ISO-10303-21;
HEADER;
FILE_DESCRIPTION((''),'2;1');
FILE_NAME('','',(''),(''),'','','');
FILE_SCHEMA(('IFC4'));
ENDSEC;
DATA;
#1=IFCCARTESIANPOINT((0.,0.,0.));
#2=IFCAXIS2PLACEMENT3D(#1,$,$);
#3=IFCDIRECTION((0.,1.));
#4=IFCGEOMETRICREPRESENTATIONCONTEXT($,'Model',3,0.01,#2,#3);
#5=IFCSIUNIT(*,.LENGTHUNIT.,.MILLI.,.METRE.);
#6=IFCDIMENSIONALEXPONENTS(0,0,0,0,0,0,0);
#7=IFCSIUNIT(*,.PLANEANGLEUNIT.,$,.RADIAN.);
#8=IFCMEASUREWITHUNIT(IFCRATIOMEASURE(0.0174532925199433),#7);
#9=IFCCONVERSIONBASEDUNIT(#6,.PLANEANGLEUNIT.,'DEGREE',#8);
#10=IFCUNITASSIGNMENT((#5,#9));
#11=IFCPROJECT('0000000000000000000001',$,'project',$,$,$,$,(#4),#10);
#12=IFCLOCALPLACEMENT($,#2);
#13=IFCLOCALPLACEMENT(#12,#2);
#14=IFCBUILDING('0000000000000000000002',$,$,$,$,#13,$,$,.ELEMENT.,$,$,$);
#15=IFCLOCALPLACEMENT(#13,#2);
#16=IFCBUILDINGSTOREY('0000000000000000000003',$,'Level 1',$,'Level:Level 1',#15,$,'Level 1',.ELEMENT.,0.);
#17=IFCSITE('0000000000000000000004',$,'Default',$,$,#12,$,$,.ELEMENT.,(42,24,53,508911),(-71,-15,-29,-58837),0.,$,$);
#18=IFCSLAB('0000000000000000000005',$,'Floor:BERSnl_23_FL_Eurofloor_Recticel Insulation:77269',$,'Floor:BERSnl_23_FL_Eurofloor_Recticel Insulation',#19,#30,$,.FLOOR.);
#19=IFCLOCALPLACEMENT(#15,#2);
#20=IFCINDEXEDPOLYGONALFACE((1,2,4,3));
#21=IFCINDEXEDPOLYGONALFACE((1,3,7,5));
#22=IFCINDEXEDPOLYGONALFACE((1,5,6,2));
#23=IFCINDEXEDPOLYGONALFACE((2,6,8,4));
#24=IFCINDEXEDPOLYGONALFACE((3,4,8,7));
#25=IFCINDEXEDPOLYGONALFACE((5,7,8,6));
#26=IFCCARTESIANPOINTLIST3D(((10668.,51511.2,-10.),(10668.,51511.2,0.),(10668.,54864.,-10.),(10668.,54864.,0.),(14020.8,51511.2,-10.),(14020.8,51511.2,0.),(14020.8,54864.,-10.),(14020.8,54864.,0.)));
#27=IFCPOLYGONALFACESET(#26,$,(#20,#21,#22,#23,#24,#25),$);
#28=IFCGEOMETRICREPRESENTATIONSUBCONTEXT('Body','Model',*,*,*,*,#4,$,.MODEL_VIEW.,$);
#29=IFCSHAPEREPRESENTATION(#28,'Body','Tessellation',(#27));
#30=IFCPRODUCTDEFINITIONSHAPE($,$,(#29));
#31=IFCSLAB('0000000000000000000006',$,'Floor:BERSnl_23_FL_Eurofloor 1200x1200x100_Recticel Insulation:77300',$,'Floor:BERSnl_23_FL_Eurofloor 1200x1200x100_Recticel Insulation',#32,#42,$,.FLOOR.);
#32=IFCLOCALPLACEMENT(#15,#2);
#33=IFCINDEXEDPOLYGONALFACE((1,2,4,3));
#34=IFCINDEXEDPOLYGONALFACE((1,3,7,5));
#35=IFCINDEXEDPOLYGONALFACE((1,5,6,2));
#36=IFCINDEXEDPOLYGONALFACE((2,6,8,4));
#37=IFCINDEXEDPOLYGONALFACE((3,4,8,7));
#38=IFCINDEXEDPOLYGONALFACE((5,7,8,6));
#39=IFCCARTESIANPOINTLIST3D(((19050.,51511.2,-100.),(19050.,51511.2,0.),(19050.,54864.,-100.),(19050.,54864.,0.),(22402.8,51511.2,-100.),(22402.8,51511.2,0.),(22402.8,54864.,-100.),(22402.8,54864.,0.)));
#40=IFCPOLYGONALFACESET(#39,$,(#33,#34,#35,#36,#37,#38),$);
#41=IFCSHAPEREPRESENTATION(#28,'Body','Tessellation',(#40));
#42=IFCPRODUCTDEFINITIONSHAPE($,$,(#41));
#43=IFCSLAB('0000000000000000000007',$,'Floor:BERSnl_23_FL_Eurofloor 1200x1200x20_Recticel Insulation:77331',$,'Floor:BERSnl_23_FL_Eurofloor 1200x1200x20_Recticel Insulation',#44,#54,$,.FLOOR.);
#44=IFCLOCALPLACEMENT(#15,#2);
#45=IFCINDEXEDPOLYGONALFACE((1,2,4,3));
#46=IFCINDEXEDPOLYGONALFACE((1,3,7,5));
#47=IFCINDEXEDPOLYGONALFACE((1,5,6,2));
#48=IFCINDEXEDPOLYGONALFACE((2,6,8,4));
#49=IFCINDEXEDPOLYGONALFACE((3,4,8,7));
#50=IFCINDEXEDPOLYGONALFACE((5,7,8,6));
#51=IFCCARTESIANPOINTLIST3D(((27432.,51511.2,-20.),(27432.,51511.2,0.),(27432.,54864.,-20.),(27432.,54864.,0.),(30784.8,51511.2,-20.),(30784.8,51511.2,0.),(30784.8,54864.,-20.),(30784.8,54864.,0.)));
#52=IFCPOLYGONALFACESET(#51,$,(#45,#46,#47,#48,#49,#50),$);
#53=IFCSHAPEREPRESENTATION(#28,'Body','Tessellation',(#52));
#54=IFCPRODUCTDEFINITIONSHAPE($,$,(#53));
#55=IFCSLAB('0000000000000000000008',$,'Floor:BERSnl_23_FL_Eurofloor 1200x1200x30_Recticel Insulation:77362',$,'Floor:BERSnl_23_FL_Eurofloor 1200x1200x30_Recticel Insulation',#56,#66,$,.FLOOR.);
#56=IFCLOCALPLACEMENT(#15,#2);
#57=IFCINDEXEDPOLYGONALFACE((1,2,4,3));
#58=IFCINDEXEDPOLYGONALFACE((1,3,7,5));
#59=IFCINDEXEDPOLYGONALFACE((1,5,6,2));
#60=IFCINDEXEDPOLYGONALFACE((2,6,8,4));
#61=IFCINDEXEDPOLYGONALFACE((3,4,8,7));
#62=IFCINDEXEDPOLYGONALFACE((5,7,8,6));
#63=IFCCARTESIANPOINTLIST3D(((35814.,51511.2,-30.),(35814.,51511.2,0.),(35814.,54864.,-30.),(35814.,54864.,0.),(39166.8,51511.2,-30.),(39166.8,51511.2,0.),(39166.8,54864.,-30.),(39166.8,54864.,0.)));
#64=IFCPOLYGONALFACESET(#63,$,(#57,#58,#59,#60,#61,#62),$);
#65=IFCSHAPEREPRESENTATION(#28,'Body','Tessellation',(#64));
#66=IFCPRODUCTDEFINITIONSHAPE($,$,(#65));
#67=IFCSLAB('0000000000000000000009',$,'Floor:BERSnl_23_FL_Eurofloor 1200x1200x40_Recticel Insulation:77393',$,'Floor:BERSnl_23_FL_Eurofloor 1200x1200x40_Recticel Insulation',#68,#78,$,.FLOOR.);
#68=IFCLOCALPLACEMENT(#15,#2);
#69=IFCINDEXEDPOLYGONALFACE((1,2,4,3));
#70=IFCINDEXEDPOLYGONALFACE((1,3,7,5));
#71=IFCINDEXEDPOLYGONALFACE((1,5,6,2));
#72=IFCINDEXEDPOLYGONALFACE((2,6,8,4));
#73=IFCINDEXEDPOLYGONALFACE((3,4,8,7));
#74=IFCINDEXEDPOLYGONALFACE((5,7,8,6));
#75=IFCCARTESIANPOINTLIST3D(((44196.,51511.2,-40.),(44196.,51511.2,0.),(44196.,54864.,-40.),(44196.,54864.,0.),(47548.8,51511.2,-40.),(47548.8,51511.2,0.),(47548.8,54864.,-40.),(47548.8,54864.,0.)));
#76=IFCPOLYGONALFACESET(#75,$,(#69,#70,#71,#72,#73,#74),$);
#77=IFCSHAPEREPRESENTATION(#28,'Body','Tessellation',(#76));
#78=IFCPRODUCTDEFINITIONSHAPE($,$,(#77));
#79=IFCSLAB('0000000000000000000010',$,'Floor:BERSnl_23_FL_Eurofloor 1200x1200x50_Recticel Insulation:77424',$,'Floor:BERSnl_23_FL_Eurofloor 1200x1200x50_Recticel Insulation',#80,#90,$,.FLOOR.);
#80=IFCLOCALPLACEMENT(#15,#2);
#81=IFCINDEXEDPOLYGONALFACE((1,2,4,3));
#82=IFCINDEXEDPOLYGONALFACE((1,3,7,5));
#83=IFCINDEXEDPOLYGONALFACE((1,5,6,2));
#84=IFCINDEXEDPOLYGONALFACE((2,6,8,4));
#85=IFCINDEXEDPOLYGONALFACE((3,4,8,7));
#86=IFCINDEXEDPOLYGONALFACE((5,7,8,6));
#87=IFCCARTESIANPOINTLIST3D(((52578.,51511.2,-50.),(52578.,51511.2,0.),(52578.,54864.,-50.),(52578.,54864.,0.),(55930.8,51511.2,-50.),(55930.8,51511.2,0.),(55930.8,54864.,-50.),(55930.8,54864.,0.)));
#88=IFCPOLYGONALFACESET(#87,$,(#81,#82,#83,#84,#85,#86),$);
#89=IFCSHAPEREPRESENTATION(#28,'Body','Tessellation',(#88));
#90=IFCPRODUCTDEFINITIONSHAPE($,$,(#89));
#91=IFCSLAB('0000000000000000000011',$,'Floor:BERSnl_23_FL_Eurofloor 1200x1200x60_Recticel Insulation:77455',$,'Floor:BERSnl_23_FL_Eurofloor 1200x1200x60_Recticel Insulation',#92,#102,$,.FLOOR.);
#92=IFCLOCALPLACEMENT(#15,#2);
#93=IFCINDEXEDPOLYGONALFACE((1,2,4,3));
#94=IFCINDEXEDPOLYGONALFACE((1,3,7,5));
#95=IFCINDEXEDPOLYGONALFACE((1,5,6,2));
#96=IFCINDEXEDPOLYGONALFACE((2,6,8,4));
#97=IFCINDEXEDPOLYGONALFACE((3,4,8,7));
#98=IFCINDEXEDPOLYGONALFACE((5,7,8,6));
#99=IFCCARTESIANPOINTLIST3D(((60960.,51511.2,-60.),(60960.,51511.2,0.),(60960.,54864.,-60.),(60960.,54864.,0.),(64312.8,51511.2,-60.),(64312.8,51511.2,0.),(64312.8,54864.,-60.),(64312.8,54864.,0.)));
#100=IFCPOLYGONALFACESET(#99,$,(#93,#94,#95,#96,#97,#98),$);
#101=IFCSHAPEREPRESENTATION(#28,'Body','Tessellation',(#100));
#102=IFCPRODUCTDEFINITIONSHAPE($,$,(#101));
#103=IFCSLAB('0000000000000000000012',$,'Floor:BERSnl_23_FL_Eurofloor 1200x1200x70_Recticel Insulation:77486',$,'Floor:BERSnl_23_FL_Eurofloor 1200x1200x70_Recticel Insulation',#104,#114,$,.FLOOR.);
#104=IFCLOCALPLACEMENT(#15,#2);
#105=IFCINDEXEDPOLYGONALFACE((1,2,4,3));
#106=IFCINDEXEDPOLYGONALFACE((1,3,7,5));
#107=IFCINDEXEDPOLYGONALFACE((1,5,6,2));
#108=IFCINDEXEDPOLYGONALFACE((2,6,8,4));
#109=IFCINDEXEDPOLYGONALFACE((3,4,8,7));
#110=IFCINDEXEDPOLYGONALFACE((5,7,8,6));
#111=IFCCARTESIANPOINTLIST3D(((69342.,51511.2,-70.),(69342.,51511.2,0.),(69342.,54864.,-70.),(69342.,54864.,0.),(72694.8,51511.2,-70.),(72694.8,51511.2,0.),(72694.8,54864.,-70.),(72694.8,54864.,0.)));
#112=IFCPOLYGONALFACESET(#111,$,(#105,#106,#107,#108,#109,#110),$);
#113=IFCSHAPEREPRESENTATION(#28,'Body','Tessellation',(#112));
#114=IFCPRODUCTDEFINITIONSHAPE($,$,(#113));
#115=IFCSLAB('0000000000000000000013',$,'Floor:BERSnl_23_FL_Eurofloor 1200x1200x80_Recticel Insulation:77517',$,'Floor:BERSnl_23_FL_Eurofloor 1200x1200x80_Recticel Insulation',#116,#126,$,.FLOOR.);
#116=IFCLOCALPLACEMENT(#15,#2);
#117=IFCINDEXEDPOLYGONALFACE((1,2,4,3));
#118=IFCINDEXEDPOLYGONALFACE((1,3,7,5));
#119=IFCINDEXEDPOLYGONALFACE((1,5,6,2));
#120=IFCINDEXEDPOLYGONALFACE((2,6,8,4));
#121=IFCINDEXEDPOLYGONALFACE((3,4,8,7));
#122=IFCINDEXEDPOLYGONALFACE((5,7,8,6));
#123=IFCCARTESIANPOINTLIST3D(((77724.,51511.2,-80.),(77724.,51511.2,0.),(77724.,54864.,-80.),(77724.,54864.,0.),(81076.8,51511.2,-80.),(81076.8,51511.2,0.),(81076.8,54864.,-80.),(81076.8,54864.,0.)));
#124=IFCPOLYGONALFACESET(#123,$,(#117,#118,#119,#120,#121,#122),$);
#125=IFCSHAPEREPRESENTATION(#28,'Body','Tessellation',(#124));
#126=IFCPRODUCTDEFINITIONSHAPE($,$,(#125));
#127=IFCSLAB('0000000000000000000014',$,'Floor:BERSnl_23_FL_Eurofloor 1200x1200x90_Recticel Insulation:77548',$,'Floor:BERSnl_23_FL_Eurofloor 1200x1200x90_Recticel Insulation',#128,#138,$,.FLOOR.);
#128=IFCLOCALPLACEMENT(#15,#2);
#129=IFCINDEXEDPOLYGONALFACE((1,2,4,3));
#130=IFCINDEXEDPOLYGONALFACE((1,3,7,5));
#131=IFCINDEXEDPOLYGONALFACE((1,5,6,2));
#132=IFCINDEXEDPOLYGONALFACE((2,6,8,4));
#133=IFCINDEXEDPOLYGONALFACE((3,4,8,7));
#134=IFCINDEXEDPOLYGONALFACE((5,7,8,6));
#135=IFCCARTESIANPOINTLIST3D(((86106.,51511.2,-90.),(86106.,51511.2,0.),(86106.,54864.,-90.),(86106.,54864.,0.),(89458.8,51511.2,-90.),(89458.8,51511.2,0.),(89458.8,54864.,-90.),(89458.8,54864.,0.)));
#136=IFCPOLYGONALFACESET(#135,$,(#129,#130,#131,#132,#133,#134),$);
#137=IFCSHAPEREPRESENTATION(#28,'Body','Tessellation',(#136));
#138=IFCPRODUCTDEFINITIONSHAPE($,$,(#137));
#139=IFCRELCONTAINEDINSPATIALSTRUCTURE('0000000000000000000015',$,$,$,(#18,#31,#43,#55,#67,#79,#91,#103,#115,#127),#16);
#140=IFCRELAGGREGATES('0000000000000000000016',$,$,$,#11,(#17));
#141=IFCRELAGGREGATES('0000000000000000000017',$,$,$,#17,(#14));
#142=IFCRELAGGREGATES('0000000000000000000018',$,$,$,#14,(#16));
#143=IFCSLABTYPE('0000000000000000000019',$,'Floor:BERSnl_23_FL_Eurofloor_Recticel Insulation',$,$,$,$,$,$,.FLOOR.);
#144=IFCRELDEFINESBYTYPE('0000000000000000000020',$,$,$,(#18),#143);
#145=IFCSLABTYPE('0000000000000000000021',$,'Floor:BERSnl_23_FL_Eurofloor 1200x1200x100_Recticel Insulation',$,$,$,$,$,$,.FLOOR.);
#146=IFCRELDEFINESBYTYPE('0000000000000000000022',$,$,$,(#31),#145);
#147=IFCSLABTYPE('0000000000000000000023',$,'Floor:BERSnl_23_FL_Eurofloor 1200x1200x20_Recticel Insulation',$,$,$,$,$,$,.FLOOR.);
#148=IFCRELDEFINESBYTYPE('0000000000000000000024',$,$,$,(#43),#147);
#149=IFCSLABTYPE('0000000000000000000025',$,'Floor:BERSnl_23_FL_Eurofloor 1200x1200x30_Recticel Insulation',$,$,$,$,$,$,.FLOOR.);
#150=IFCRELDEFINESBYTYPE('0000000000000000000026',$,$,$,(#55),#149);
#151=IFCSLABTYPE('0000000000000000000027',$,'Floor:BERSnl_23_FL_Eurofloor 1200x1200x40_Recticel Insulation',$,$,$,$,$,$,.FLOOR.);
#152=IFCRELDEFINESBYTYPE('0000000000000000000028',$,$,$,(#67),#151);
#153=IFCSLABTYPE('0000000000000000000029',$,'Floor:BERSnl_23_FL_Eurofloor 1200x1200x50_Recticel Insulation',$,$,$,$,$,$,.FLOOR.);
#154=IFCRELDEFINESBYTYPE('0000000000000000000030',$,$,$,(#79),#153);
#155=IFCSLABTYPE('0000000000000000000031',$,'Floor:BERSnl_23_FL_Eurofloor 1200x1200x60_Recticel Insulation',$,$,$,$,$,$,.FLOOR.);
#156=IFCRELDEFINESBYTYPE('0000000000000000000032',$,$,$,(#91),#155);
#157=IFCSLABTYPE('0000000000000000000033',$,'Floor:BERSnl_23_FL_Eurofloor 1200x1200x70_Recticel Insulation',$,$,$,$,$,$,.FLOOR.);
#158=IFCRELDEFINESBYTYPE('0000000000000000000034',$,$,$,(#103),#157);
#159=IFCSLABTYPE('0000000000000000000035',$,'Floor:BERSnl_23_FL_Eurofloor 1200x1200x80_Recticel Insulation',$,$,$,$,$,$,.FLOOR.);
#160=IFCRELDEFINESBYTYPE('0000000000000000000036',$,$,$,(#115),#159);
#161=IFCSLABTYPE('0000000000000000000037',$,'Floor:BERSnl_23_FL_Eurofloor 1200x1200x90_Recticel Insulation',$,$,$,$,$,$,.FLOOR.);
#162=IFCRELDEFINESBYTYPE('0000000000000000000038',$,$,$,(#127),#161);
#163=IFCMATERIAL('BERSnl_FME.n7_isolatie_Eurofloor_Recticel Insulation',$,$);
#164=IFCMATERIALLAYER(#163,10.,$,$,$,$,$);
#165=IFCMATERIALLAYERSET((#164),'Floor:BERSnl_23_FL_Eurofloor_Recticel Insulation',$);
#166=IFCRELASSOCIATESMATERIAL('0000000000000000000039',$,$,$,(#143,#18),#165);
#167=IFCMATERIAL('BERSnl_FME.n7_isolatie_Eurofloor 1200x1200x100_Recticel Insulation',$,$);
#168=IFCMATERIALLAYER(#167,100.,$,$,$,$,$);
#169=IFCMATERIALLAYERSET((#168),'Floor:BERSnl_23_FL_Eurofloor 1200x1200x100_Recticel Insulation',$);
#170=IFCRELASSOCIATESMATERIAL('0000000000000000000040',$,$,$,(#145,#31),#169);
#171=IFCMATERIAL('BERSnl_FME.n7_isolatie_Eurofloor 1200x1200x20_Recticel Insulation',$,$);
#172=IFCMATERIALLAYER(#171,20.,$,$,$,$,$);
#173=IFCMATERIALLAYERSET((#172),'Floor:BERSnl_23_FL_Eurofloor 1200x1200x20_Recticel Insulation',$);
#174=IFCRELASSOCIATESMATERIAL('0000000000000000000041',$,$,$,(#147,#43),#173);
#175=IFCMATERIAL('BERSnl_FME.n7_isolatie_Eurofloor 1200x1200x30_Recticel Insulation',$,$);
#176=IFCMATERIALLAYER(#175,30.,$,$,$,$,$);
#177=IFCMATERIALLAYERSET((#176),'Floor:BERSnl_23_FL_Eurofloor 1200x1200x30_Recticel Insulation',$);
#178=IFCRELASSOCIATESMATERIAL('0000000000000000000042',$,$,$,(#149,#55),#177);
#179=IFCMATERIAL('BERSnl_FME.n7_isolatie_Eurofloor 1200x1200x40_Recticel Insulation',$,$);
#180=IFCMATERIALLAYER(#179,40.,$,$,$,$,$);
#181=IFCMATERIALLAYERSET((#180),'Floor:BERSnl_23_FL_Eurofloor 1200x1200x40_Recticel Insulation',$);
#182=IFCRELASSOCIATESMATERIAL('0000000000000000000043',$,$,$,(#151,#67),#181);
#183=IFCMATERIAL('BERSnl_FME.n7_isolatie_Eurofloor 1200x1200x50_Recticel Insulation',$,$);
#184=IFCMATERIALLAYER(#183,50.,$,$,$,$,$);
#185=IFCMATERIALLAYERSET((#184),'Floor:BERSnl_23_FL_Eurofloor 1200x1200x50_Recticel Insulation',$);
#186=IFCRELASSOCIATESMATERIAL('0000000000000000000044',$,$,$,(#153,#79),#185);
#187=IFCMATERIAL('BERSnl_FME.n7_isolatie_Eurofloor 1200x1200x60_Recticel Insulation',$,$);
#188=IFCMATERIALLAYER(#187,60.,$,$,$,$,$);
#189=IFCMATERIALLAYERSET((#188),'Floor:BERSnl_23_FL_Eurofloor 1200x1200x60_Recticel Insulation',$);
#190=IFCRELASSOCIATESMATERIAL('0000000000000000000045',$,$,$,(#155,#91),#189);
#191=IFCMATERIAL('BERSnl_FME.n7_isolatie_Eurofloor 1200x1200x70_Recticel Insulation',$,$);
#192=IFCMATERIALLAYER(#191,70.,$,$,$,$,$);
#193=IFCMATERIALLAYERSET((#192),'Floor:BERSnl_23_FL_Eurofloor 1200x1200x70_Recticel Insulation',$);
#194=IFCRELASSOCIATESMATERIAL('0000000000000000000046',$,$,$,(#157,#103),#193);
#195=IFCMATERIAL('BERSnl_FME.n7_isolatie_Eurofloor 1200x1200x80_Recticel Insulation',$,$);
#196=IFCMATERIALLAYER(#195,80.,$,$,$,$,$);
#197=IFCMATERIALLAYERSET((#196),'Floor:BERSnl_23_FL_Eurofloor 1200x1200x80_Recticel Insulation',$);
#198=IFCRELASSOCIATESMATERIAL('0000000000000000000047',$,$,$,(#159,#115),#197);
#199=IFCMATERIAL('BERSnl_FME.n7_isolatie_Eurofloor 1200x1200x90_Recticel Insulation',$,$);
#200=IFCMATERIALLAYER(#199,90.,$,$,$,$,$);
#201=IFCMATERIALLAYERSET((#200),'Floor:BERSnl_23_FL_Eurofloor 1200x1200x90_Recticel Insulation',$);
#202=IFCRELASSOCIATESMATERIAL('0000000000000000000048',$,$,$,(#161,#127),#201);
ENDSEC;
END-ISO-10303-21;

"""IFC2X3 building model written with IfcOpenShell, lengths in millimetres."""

from ifc_helpers import new_model, entity, si_unit, converted_unit, direction, frame, origin, origin_2d_with_axis, place, context, subcontext, project, spatial, rectangle, extrude, material, layer, layer_set, layer_usage, type_object, element, save


model = new_model("IFC2X3")

# Units and contexts
model_context = context("Model", 3, precision=0.01, world=origin(), true_north=direction((0.0, 1.0)))
body_context = subcontext(model_context, "Body", "Model", "MODEL_VIEW")
ifc_project = project(units=[si_unit("LENGTHUNIT", "METRE", prefix="MILLI"), converted_unit("PLANEANGLEUNIT", "DEGREE", entity("IfcRatioMeasure", 0.0174532925199433), si_unit("PLANEANGLEUNIT", "RADIAN"), dimensions=[0, 0, 0, 0, 0, 0, 0])], contexts=[model_context])

# Site, building, storey
site_placement = place(None, origin())
site = spatial("IfcSite", under=ifc_project, at=site_placement, Name="Default", CompositionType="ELEMENT", RefLatitude=(42, 24, 53, 508911), RefLongitude=(-71, -15, -29, -58837), RefElevation=0.0)
building_placement = place(site_placement, origin())
building = spatial("IfcBuilding", under=site, at=building_placement, CompositionType="ELEMENT")
storey_placement = place(building_placement, origin())
storey = spatial("IfcBuildingStorey", under=building, at=storey_placement, Name="Level 1", ObjectType="Level:Level 1", LongName="Level 1", CompositionType="ELEMENT", Elevation=0.0)

# Slabs
ifc_material_1 = material(Name="BERSnl_FME.n7_isolatie_Eurofloor_Recticel Insulation")
ifc_layer_1 = layer(ifc_material_1, 10.0)
ifc_layer_set_1 = layer_set([ifc_layer_1], Name="Floor:BERSnl_23_FL_Eurofloor_Recticel Insulation")
ifc_layer_usage_1 = layer_usage(ifc_layer_set_1, "AXIS3", "POSITIVE", 0.0)
slab_type_1 = type_object("IfcSlabType", Name="Floor:BERSnl_23_FL_Eurofloor_Recticel Insulation", PredefinedType="FLOOR", material=ifc_layer_set_1)
slab_1_placement = place(storey_placement, origin())
element("IfcSlab", 1, at=slab_1_placement, inside=storey, type_object=slab_type_1, material=ifc_layer_usage_1, Name="Floor:BERSnl_23_FL_Eurofloor_Recticel Insulation:77269", ObjectType="Floor:BERSnl_23_FL_Eurofloor_Recticel Insulation", PredefinedType="FLOOR", context=body_context, shape_type="SweptSolid", body=[
    extrude(rectangle(XDim=3352.8, YDim=3352.8, at=origin_2d_with_axis()), frame((12344.4, 53187.6, 0.0), z_axis=(0.0, 0.0, -1.0), x_axis=(0.0, 1.0, 0.0)), (0.0, 0.0, 1.0), 10.0),
])
ifc_material_2 = material(Name="BERSnl_FME.n7_isolatie_Eurofloor 1200x1200x100_Recticel Insulation")
ifc_layer_2 = layer(ifc_material_2, 100.0)
ifc_layer_set_2 = layer_set([ifc_layer_2], Name="Floor:BERSnl_23_FL_Eurofloor 1200x1200x100_Recticel Insulation")
ifc_layer_usage_2 = layer_usage(ifc_layer_set_2, "AXIS3", "POSITIVE", 0.0)
slab_type_2 = type_object("IfcSlabType", Name="Floor:BERSnl_23_FL_Eurofloor 1200x1200x100_Recticel Insulation", PredefinedType="FLOOR", material=ifc_layer_set_2)
slab_2_placement = place(storey_placement, origin())
element("IfcSlab", 2, at=slab_2_placement, inside=storey, type_object=slab_type_2, material=ifc_layer_usage_2, Name="Floor:BERSnl_23_FL_Eurofloor 1200x1200x100_Recticel Insulation:77300", ObjectType="Floor:BERSnl_23_FL_Eurofloor 1200x1200x100_Recticel Insulation", PredefinedType="FLOOR", context=body_context, shape_type="SweptSolid", body=[
    extrude(rectangle(XDim=3352.8, YDim=3352.8, at=origin_2d_with_axis()), frame((20726.4, 53187.6, 0.0), z_axis=(0.0, 0.0, -1.0), x_axis=(0.0, 1.0, 0.0)), (0.0, 0.0, 1.0), 100.0),
])
ifc_material_3 = material(Name="BERSnl_FME.n7_isolatie_Eurofloor 1200x1200x20_Recticel Insulation")
ifc_layer_3 = layer(ifc_material_3, 20.0)
ifc_layer_set_3 = layer_set([ifc_layer_3], Name="Floor:BERSnl_23_FL_Eurofloor 1200x1200x20_Recticel Insulation")
ifc_layer_usage_3 = layer_usage(ifc_layer_set_3, "AXIS3", "POSITIVE", 0.0)
slab_type_3 = type_object("IfcSlabType", Name="Floor:BERSnl_23_FL_Eurofloor 1200x1200x20_Recticel Insulation", PredefinedType="FLOOR", material=ifc_layer_set_3)
slab_3_placement = place(storey_placement, origin())
element("IfcSlab", 3, at=slab_3_placement, inside=storey, type_object=slab_type_3, material=ifc_layer_usage_3, Name="Floor:BERSnl_23_FL_Eurofloor 1200x1200x20_Recticel Insulation:77331", ObjectType="Floor:BERSnl_23_FL_Eurofloor 1200x1200x20_Recticel Insulation", PredefinedType="FLOOR", context=body_context, shape_type="SweptSolid", body=[
    extrude(rectangle(XDim=3352.8, YDim=3352.8, at=origin_2d_with_axis()), frame((29108.4, 53187.6, 0.0), z_axis=(0.0, 0.0, -1.0), x_axis=(0.0, 1.0, 0.0)), (0.0, 0.0, 1.0), 20.0),
])
ifc_material_4 = material(Name="BERSnl_FME.n7_isolatie_Eurofloor 1200x1200x30_Recticel Insulation")
ifc_layer_4 = layer(ifc_material_4, 30.0)
ifc_layer_set_4 = layer_set([ifc_layer_4], Name="Floor:BERSnl_23_FL_Eurofloor 1200x1200x30_Recticel Insulation")
ifc_layer_usage_4 = layer_usage(ifc_layer_set_4, "AXIS3", "POSITIVE", 0.0)
slab_type_4 = type_object("IfcSlabType", Name="Floor:BERSnl_23_FL_Eurofloor 1200x1200x30_Recticel Insulation", PredefinedType="FLOOR", material=ifc_layer_set_4)
slab_4_placement = place(storey_placement, origin())
element("IfcSlab", 4, at=slab_4_placement, inside=storey, type_object=slab_type_4, material=ifc_layer_usage_4, Name="Floor:BERSnl_23_FL_Eurofloor 1200x1200x30_Recticel Insulation:77362", ObjectType="Floor:BERSnl_23_FL_Eurofloor 1200x1200x30_Recticel Insulation", PredefinedType="FLOOR", context=body_context, shape_type="SweptSolid", body=[
    extrude(rectangle(XDim=3352.8, YDim=3352.8, at=origin_2d_with_axis()), frame((37490.4, 53187.6, 0.0), z_axis=(0.0, 0.0, -1.0), x_axis=(0.0, 1.0, 0.0)), (0.0, 0.0, 1.0), 30.0),
])
ifc_material_5 = material(Name="BERSnl_FME.n7_isolatie_Eurofloor 1200x1200x40_Recticel Insulation")
ifc_layer_5 = layer(ifc_material_5, 40.0)
ifc_layer_set_5 = layer_set([ifc_layer_5], Name="Floor:BERSnl_23_FL_Eurofloor 1200x1200x40_Recticel Insulation")
ifc_layer_usage_5 = layer_usage(ifc_layer_set_5, "AXIS3", "POSITIVE", 0.0)
slab_type_5 = type_object("IfcSlabType", Name="Floor:BERSnl_23_FL_Eurofloor 1200x1200x40_Recticel Insulation", PredefinedType="FLOOR", material=ifc_layer_set_5)
slab_5_placement = place(storey_placement, origin())
element("IfcSlab", 5, at=slab_5_placement, inside=storey, type_object=slab_type_5, material=ifc_layer_usage_5, Name="Floor:BERSnl_23_FL_Eurofloor 1200x1200x40_Recticel Insulation:77393", ObjectType="Floor:BERSnl_23_FL_Eurofloor 1200x1200x40_Recticel Insulation", PredefinedType="FLOOR", context=body_context, shape_type="SweptSolid", body=[
    extrude(rectangle(XDim=3352.8, YDim=3352.8, at=origin_2d_with_axis()), frame((45872.4, 53187.6, 0.0), z_axis=(0.0, 0.0, -1.0), x_axis=(0.0, 1.0, 0.0)), (0.0, 0.0, 1.0), 40.0),
])
ifc_material_6 = material(Name="BERSnl_FME.n7_isolatie_Eurofloor 1200x1200x50_Recticel Insulation")
ifc_layer_6 = layer(ifc_material_6, 50.0)
ifc_layer_set_6 = layer_set([ifc_layer_6], Name="Floor:BERSnl_23_FL_Eurofloor 1200x1200x50_Recticel Insulation")
ifc_layer_usage_6 = layer_usage(ifc_layer_set_6, "AXIS3", "POSITIVE", 0.0)
slab_type_6 = type_object("IfcSlabType", Name="Floor:BERSnl_23_FL_Eurofloor 1200x1200x50_Recticel Insulation", PredefinedType="FLOOR", material=ifc_layer_set_6)
slab_6_placement = place(storey_placement, origin())
element("IfcSlab", 6, at=slab_6_placement, inside=storey, type_object=slab_type_6, material=ifc_layer_usage_6, Name="Floor:BERSnl_23_FL_Eurofloor 1200x1200x50_Recticel Insulation:77424", ObjectType="Floor:BERSnl_23_FL_Eurofloor 1200x1200x50_Recticel Insulation", PredefinedType="FLOOR", context=body_context, shape_type="SweptSolid", body=[
    extrude(rectangle(XDim=3352.8, YDim=3352.8, at=origin_2d_with_axis()), frame((54254.4, 53187.6, 0.0), z_axis=(0.0, 0.0, -1.0), x_axis=(0.0, 1.0, 0.0)), (0.0, 0.0, 1.0), 50.0),
])
ifc_material_7 = material(Name="BERSnl_FME.n7_isolatie_Eurofloor 1200x1200x60_Recticel Insulation")
ifc_layer_7 = layer(ifc_material_7, 60.0)
ifc_layer_set_7 = layer_set([ifc_layer_7], Name="Floor:BERSnl_23_FL_Eurofloor 1200x1200x60_Recticel Insulation")
ifc_layer_usage_7 = layer_usage(ifc_layer_set_7, "AXIS3", "POSITIVE", 0.0)
slab_type_7 = type_object("IfcSlabType", Name="Floor:BERSnl_23_FL_Eurofloor 1200x1200x60_Recticel Insulation", PredefinedType="FLOOR", material=ifc_layer_set_7)
slab_7_placement = place(storey_placement, origin())
element("IfcSlab", 7, at=slab_7_placement, inside=storey, type_object=slab_type_7, material=ifc_layer_usage_7, Name="Floor:BERSnl_23_FL_Eurofloor 1200x1200x60_Recticel Insulation:77455", ObjectType="Floor:BERSnl_23_FL_Eurofloor 1200x1200x60_Recticel Insulation", PredefinedType="FLOOR", context=body_context, shape_type="SweptSolid", body=[
    extrude(rectangle(XDim=3352.8, YDim=3352.8, at=origin_2d_with_axis()), frame((62636.4, 53187.6, 0.0), z_axis=(0.0, 0.0, -1.0), x_axis=(0.0, 1.0, 0.0)), (0.0, 0.0, 1.0), 60.0),
])
ifc_material_8 = material(Name="BERSnl_FME.n7_isolatie_Eurofloor 1200x1200x70_Recticel Insulation")
ifc_layer_8 = layer(ifc_material_8, 70.0)
ifc_layer_set_8 = layer_set([ifc_layer_8], Name="Floor:BERSnl_23_FL_Eurofloor 1200x1200x70_Recticel Insulation")
ifc_layer_usage_8 = layer_usage(ifc_layer_set_8, "AXIS3", "POSITIVE", 0.0)
slab_type_8 = type_object("IfcSlabType", Name="Floor:BERSnl_23_FL_Eurofloor 1200x1200x70_Recticel Insulation", PredefinedType="FLOOR", material=ifc_layer_set_8)
slab_8_placement = place(storey_placement, origin())
element("IfcSlab", 8, at=slab_8_placement, inside=storey, type_object=slab_type_8, material=ifc_layer_usage_8, Name="Floor:BERSnl_23_FL_Eurofloor 1200x1200x70_Recticel Insulation:77486", ObjectType="Floor:BERSnl_23_FL_Eurofloor 1200x1200x70_Recticel Insulation", PredefinedType="FLOOR", context=body_context, shape_type="SweptSolid", body=[
    extrude(rectangle(XDim=3352.8, YDim=3352.8, at=origin_2d_with_axis()), frame((71018.4, 53187.6, 0.0), z_axis=(0.0, 0.0, -1.0), x_axis=(0.0, 1.0, 0.0)), (0.0, 0.0, 1.0), 70.0),
])
ifc_material_9 = material(Name="BERSnl_FME.n7_isolatie_Eurofloor 1200x1200x80_Recticel Insulation")
ifc_layer_9 = layer(ifc_material_9, 80.0)
ifc_layer_set_9 = layer_set([ifc_layer_9], Name="Floor:BERSnl_23_FL_Eurofloor 1200x1200x80_Recticel Insulation")
ifc_layer_usage_9 = layer_usage(ifc_layer_set_9, "AXIS3", "POSITIVE", 0.0)
slab_type_9 = type_object("IfcSlabType", Name="Floor:BERSnl_23_FL_Eurofloor 1200x1200x80_Recticel Insulation", PredefinedType="FLOOR", material=ifc_layer_set_9)
slab_9_placement = place(storey_placement, origin())
element("IfcSlab", 9, at=slab_9_placement, inside=storey, type_object=slab_type_9, material=ifc_layer_usage_9, Name="Floor:BERSnl_23_FL_Eurofloor 1200x1200x80_Recticel Insulation:77517", ObjectType="Floor:BERSnl_23_FL_Eurofloor 1200x1200x80_Recticel Insulation", PredefinedType="FLOOR", context=body_context, shape_type="SweptSolid", body=[
    extrude(rectangle(XDim=3352.8, YDim=3352.8, at=origin_2d_with_axis()), frame((79400.4, 53187.6, 0.0), z_axis=(0.0, 0.0, -1.0), x_axis=(0.0, 1.0, 0.0)), (0.0, 0.0, 1.0), 80.0),
])
ifc_material_10 = material(Name="BERSnl_FME.n7_isolatie_Eurofloor 1200x1200x90_Recticel Insulation")
ifc_layer_10 = layer(ifc_material_10, 90.0)
ifc_layer_set_10 = layer_set([ifc_layer_10], Name="Floor:BERSnl_23_FL_Eurofloor 1200x1200x90_Recticel Insulation")
ifc_layer_usage_10 = layer_usage(ifc_layer_set_10, "AXIS3", "POSITIVE", 0.0)
slab_type_10 = type_object("IfcSlabType", Name="Floor:BERSnl_23_FL_Eurofloor 1200x1200x90_Recticel Insulation", PredefinedType="FLOOR", material=ifc_layer_set_10)
slab_10_placement = place(storey_placement, origin())
element("IfcSlab", 10, at=slab_10_placement, inside=storey, type_object=slab_type_10, material=ifc_layer_usage_10, Name="Floor:BERSnl_23_FL_Eurofloor 1200x1200x90_Recticel Insulation:77548", ObjectType="Floor:BERSnl_23_FL_Eurofloor 1200x1200x90_Recticel Insulation", PredefinedType="FLOOR", context=body_context, shape_type="SweptSolid", body=[
    extrude(rectangle(XDim=3352.8, YDim=3352.8, at=origin_2d_with_axis()), frame((87782.4, 53187.6, 0.0), z_axis=(0.0, 0.0, -1.0), x_axis=(0.0, 1.0, 0.0)), (0.0, 0.0, 1.0), 90.0),
])

save(model, "model.ifc")
